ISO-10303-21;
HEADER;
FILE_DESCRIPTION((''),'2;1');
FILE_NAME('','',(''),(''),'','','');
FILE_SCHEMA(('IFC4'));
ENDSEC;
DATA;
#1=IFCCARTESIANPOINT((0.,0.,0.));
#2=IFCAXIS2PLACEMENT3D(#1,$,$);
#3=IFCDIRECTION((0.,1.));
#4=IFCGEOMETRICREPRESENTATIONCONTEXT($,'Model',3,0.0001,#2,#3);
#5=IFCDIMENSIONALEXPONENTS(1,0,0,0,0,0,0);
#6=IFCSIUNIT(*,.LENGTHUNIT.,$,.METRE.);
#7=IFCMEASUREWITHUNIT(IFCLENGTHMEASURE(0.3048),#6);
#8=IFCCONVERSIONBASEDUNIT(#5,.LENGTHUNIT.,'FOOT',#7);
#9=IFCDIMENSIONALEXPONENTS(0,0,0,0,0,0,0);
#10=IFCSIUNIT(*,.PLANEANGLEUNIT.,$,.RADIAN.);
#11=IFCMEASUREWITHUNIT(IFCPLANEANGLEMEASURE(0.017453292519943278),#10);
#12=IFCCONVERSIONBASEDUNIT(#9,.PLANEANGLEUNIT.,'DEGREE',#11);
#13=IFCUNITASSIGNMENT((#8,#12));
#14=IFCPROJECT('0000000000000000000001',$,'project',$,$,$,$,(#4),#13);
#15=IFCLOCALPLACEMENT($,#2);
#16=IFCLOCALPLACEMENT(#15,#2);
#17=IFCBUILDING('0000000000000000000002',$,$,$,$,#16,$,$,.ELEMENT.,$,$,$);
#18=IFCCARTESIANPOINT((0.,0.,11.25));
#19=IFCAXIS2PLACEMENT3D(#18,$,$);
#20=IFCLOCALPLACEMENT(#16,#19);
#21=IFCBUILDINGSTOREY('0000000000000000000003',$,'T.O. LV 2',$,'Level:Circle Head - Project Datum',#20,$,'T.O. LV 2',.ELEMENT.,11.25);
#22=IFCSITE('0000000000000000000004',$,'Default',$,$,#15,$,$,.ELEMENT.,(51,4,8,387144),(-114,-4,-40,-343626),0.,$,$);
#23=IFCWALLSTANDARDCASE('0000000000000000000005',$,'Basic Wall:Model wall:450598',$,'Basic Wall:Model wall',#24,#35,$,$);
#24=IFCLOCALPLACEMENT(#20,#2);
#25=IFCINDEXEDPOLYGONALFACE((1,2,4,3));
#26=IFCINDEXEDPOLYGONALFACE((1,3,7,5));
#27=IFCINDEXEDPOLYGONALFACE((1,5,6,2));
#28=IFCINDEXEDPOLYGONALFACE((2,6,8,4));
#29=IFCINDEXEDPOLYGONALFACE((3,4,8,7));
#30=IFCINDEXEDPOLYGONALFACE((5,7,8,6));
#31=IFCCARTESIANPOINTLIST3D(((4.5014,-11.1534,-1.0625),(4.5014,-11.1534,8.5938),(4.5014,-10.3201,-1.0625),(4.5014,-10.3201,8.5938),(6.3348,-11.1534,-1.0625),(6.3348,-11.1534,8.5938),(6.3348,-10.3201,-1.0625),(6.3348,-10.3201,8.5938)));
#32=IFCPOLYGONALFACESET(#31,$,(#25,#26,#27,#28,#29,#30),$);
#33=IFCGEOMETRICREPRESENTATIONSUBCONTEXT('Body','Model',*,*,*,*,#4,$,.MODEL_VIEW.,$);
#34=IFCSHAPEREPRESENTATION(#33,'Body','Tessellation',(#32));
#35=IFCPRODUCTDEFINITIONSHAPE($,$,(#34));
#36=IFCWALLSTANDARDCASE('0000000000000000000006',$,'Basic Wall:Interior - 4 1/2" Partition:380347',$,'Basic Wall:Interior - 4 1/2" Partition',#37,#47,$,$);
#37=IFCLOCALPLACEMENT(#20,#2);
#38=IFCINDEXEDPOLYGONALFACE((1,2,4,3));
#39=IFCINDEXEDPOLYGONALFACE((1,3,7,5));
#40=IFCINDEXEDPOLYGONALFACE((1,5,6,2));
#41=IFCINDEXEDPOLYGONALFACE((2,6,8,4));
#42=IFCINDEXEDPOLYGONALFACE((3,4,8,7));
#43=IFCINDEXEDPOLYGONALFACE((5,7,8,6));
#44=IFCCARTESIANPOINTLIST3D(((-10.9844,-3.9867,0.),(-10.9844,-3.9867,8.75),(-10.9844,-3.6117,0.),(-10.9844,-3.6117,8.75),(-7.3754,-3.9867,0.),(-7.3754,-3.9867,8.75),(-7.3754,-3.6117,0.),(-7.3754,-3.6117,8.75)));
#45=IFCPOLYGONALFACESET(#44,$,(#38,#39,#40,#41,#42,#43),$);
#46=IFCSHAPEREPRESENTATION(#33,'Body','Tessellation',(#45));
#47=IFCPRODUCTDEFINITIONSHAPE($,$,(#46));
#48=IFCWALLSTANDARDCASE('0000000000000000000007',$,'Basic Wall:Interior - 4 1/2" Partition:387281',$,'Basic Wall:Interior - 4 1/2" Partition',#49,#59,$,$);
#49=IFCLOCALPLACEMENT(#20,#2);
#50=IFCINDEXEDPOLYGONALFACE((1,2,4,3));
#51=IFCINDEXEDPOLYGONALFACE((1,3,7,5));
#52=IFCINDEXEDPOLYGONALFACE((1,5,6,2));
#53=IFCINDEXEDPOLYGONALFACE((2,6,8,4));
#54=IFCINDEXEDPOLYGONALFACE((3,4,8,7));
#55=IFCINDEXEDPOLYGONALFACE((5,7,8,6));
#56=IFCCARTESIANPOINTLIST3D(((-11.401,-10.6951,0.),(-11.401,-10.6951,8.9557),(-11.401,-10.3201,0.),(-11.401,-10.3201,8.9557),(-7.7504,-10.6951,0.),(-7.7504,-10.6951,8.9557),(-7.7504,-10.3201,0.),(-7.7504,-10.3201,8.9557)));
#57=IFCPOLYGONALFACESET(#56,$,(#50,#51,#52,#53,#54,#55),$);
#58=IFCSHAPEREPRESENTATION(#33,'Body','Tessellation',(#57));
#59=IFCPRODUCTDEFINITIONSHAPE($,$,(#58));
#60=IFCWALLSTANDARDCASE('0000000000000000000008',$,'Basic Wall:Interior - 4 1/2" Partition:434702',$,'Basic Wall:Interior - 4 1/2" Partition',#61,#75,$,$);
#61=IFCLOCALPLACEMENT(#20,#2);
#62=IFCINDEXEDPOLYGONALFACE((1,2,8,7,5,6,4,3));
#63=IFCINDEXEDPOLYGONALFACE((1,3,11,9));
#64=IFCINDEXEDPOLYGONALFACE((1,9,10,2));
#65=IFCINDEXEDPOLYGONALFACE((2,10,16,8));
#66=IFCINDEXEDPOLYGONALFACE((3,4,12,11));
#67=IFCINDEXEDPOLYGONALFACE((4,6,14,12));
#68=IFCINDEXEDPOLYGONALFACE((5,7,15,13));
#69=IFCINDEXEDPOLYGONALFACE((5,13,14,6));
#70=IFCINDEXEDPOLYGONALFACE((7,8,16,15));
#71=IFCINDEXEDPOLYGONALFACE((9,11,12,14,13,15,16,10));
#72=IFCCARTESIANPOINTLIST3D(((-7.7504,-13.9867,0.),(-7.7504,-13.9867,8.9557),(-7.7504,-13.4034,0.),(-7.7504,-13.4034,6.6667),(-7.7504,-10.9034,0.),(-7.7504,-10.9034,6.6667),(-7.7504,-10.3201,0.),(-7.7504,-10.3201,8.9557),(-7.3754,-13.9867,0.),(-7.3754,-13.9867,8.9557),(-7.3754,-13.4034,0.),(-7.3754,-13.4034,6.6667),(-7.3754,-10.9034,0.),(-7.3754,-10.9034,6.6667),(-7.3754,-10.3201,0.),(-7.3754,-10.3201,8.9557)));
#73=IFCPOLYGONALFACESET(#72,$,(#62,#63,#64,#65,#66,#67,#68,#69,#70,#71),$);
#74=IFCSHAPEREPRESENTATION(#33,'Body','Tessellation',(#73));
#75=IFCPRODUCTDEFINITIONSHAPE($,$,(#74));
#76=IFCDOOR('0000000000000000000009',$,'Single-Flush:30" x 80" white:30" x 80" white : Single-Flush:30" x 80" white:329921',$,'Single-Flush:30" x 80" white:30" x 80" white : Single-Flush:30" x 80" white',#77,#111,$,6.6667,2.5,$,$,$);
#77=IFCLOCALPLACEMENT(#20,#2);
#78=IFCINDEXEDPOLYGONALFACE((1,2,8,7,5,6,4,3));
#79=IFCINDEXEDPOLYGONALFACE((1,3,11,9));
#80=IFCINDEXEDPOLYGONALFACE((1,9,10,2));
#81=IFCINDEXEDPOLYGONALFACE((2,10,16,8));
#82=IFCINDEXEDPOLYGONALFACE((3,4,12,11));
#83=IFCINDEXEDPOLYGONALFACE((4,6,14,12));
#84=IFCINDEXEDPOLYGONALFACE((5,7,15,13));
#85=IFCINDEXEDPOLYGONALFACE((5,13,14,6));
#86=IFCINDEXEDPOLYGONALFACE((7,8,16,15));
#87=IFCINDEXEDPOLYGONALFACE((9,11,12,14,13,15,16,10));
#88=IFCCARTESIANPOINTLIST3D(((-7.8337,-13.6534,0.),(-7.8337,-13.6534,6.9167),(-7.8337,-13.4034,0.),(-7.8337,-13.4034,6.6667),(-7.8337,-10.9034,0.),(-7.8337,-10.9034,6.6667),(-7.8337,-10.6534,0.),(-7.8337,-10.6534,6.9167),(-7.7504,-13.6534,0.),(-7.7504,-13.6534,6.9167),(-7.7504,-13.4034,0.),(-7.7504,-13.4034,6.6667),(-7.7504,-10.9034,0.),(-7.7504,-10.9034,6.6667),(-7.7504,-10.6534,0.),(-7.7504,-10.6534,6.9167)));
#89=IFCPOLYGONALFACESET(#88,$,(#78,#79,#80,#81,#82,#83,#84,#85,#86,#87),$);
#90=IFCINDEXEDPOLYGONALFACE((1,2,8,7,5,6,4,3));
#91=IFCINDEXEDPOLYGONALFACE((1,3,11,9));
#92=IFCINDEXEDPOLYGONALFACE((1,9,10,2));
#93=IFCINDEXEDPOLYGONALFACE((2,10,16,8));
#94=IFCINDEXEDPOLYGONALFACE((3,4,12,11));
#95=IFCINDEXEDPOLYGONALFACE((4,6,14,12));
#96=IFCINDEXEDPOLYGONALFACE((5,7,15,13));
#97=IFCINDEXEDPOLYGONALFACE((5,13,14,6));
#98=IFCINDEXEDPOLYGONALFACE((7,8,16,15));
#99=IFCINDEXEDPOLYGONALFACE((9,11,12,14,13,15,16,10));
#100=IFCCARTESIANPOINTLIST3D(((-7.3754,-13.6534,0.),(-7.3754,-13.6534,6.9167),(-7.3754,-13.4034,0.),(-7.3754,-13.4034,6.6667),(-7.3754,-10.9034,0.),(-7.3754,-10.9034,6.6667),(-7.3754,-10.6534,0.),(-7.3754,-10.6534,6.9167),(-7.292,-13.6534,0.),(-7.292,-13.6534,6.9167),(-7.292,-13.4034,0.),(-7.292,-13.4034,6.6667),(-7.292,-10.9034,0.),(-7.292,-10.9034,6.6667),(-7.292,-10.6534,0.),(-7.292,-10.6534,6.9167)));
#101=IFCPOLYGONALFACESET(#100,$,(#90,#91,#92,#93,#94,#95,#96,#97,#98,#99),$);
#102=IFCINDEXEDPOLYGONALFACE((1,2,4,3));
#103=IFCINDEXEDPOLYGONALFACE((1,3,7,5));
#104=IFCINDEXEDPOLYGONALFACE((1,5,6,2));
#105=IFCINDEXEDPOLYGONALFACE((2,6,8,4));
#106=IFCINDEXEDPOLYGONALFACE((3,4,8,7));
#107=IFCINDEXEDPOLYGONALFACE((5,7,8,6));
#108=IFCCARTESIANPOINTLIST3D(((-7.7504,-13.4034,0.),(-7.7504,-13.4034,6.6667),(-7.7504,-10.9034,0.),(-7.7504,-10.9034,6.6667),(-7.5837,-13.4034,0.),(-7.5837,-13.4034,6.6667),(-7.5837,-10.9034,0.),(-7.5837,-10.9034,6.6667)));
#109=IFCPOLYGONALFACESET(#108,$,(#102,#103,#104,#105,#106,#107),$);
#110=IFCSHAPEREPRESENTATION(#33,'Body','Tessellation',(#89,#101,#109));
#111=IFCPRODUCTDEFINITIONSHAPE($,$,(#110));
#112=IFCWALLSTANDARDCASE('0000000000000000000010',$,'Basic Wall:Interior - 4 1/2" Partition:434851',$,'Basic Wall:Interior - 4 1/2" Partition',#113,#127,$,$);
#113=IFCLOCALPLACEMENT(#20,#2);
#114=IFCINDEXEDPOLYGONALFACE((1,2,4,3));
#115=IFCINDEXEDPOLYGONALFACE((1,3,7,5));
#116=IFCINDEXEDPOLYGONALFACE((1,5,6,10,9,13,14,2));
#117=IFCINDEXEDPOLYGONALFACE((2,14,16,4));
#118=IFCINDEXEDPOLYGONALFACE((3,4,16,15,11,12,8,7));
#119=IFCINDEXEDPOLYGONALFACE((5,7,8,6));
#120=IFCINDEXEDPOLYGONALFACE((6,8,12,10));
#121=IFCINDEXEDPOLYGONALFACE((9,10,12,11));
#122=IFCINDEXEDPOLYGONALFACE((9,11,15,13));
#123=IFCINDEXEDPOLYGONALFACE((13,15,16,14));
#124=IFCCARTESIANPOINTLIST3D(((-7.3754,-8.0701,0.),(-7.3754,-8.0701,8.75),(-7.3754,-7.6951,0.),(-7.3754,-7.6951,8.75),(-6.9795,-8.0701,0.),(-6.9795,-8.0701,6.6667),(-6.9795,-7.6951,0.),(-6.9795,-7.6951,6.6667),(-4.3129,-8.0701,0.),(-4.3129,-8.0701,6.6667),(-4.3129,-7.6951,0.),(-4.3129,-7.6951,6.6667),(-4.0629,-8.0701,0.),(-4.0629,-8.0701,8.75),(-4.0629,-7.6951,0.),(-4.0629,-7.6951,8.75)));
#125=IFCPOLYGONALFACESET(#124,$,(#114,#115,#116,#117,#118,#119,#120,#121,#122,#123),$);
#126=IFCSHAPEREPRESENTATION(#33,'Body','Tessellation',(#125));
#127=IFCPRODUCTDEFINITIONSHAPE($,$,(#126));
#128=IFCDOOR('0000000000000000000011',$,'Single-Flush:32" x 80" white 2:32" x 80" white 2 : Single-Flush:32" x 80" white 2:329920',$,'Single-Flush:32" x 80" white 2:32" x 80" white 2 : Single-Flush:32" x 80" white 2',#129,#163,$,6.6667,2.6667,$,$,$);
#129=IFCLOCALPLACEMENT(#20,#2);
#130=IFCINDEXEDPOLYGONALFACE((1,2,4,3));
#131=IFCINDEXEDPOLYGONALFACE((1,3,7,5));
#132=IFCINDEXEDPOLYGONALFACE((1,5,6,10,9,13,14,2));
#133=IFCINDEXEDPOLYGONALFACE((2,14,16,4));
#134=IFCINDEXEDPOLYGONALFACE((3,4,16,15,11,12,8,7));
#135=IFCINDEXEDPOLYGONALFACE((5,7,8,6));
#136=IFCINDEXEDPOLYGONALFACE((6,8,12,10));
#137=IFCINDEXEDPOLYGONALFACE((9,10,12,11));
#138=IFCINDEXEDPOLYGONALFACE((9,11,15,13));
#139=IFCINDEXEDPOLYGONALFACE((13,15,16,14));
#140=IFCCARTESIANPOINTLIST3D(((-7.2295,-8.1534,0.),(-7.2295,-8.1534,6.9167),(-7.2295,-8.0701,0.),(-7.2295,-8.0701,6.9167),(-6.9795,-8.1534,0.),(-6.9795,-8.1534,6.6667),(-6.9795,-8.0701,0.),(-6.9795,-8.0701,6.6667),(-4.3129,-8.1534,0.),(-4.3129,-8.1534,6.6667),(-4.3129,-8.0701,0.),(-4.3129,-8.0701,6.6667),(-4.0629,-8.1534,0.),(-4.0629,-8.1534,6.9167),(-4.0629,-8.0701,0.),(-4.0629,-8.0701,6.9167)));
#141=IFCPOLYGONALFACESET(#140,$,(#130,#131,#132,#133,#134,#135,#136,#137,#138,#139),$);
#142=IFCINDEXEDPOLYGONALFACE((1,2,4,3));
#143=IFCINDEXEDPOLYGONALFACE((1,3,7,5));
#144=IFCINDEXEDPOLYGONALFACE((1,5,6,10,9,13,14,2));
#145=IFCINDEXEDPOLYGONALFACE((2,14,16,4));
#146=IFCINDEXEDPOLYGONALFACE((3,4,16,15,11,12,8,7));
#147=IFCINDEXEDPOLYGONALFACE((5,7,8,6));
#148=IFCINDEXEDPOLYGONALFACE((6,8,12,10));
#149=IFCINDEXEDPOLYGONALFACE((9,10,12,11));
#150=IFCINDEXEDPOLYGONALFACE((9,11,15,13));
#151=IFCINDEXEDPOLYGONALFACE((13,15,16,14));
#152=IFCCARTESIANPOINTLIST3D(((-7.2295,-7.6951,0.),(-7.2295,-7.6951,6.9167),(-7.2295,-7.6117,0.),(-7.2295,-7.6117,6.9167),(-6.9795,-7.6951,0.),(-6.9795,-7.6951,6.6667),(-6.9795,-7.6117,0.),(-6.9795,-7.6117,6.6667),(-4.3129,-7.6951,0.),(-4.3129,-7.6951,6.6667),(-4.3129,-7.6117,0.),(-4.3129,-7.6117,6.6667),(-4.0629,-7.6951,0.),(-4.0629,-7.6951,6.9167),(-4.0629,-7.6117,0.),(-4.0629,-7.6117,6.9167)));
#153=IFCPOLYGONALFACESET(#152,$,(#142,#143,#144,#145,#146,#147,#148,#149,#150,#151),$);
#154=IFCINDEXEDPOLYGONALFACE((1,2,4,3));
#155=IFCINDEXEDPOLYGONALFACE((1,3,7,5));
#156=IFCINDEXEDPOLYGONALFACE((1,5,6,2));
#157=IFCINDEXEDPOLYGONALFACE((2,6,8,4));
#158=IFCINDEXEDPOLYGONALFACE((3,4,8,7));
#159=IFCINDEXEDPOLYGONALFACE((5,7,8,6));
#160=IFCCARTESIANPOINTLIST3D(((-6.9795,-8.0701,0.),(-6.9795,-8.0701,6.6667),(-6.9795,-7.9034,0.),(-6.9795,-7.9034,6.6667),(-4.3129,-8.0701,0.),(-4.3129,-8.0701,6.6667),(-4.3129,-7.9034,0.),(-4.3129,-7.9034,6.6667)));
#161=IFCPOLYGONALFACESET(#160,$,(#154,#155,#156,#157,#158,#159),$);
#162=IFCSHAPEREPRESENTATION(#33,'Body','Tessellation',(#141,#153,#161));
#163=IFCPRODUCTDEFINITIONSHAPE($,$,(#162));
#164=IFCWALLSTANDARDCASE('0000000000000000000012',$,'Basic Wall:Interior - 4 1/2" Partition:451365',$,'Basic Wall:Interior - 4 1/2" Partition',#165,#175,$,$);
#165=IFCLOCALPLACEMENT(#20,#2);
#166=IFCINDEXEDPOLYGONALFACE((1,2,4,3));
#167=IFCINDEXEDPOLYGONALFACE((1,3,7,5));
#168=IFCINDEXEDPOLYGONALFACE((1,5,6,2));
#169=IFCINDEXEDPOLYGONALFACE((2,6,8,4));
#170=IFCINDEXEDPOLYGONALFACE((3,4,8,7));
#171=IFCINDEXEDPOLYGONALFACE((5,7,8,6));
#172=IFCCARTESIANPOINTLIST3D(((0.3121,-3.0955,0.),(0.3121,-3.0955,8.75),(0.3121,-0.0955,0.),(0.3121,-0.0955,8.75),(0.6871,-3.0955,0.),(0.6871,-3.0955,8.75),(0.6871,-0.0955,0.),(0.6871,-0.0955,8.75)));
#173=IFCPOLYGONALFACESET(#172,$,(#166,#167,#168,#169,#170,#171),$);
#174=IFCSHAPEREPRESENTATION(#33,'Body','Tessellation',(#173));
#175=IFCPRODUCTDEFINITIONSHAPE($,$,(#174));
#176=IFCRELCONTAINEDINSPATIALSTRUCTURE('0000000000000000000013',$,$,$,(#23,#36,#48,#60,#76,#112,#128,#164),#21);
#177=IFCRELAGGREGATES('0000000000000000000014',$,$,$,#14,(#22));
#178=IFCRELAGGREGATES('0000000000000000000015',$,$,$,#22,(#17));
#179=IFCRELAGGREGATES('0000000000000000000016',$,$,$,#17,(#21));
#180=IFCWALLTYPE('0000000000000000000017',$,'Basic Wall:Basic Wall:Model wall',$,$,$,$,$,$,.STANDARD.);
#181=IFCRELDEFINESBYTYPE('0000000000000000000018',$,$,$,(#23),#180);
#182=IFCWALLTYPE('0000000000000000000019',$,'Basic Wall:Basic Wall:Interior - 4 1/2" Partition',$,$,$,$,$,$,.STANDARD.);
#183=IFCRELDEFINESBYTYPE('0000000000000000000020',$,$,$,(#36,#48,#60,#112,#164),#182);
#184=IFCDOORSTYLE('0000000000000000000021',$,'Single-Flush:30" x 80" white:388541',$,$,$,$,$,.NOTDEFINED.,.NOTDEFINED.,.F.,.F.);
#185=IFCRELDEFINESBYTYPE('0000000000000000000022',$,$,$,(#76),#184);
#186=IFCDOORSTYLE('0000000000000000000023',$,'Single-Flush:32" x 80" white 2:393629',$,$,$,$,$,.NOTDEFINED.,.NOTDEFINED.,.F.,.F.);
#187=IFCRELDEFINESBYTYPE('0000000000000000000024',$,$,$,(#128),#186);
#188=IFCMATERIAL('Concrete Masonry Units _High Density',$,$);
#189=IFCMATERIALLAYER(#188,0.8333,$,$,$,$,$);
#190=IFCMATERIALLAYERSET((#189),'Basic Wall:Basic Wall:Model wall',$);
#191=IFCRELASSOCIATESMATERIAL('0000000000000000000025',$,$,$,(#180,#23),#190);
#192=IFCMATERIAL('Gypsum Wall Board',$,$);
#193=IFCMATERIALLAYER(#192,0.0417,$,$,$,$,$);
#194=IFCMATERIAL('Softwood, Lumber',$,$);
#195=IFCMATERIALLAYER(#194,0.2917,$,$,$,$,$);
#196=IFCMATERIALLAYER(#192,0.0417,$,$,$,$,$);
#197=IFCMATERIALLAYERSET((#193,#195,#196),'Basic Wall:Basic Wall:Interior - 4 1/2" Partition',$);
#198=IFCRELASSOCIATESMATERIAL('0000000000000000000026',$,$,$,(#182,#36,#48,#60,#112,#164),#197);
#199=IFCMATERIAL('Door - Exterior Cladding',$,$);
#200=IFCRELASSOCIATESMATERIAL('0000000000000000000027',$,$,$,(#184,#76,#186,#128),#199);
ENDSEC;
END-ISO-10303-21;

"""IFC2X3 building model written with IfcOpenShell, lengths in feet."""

from ifc_helpers import new_model, entity, si_unit, converted_unit, direction, frame, frame_2d, origin, origin_2d_with_axis, place, context, subcontext, project, spatial, polyline, rectangle, outline, extrude, source, transform, mapped, material, layer, layer_set, layer_usage, type_object, type_shapes, element, fill, save


model = new_model("IFC2X3")

# Units and contexts
model_context = context("Model", 3, precision=0.0001, world=origin(), true_north=direction((0.0, 1.0)))
body_context = subcontext(model_context, "Body", "Model", "MODEL_VIEW")
ifc_project = project(units=[converted_unit("LENGTHUNIT", "FOOT", entity("IfcLengthMeasure", 0.3048), si_unit("LENGTHUNIT", "METRE"), dimensions=[1, 0, 0, 0, 0, 0, 0]), converted_unit("PLANEANGLEUNIT", "DEGREE", entity("IfcPlaneAngleMeasure", 0.017453292519943278), si_unit("PLANEANGLEUNIT", "RADIAN"), dimensions=[0, 0, 0, 0, 0, 0, 0])], contexts=[model_context])

# Site, building, storey
site_placement = place(None, origin())
site = spatial("IfcSite", under=ifc_project, at=site_placement, Name="Default", CompositionType="ELEMENT", RefLatitude=(51, 4, 8, 387144), RefLongitude=(-114, -4, -40, -343626), RefElevation=0.0)
building_placement = place(site_placement, origin())
building = spatial("IfcBuilding", under=site, at=building_placement, CompositionType="ELEMENT")
storey_placement = place(building_placement, frame((0.0, 0.0, 11.25)))
storey = spatial("IfcBuildingStorey", under=building, at=storey_placement, Name="T.O. LV 2", ObjectType="Level:Circle Head - Project Datum", LongName="T.O. LV 2", CompositionType="ELEMENT", Elevation=11.25)

# Shared definitions
ifc_material_1 = material(Name="Gypsum Wall Board")

# Shared definitions
ifc_material_2 = material(Name="Concrete Masonry Units _High Density")
ifc_layer_1 = layer(ifc_material_2, 0.8333)
ifc_layer_set_1 = layer_set([ifc_layer_1], Name="Basic Wall:Basic Wall:Model wall")
wall_type_1 = type_object("IfcWallType", Name="Basic Wall:Basic Wall:Model wall", PredefinedType="STANDARD", material=ifc_layer_set_1)

# Walls
ifc_layer_usage_1 = layer_usage(ifc_layer_set_1, "AXIS2", "NEGATIVE", 0.4167)
wall_1_placement = place(storey_placement, frame((6.3348, -10.7367, -1.0625), z_axis=(0.0, 0.0, 1.0), x_axis=(-1.0, 0.0, 0.0)))
element("IfcWallStandardCase", 1, at=wall_1_placement, inside=storey, type_object=wall_type_1, material=ifc_layer_usage_1, Name="Basic Wall:Model wall:450598", ObjectType="Basic Wall:Model wall", context=body_context, shape_type="SweptSolid", body=[
    extrude(rectangle(XDim=1.8333, YDim=0.8333, at=frame_2d((0.9167, 0.0), x_axis=(-1.0, 0.0))), origin(), (0.0, 0.0, 1.0), 9.6563),
])
ifc_layer_2 = layer(ifc_material_1, 0.0417)
ifc_material_3 = material(Name="Softwood, Lumber")
ifc_layer_3 = layer(ifc_material_3, 0.2917)
ifc_layer_4 = layer(ifc_material_1, 0.0417)
ifc_layer_set_2 = layer_set([ifc_layer_2, ifc_layer_3, ifc_layer_4], Name="Basic Wall:Basic Wall:Interior - 4 1/2\" Partition")
ifc_layer_usage_2 = layer_usage(ifc_layer_set_2, "AXIS2", "NEGATIVE", 0.1875)
wall_type_2 = type_object("IfcWallType", Name="Basic Wall:Basic Wall:Interior - 4 1/2\" Partition", PredefinedType="STANDARD", material=ifc_layer_set_2)
wall_2_placement = place(storey_placement, frame((-10.9844, -3.7992, 0.0)))
element("IfcWallStandardCase", 2, at=wall_2_placement, inside=storey, type_object=wall_type_2, material=ifc_layer_usage_2, Name="Basic Wall:Interior - 4 1/2\" Partition:380347", ObjectType="Basic Wall:Interior - 4 1/2\" Partition", context=body_context, shape_type="SweptSolid", body=[
    extrude(rectangle(XDim=3.609, YDim=0.375, at=frame_2d((1.8045, 0.0), x_axis=(-1.0, 0.0))), origin(), (0.0, 0.0, 1.0), 8.75),
])
ifc_layer_usage_3 = layer_usage(ifc_layer_set_2, "AXIS2", "NEGATIVE", 0.1875)
wall_3_placement = place(storey_placement, frame((-7.7504, -10.5076, 0.0), z_axis=(0.0, 0.0, 1.0), x_axis=(-1.0, 0.0, 0.0)))
element("IfcWallStandardCase", 3, at=wall_3_placement, inside=storey, type_object=wall_type_2, material=ifc_layer_usage_3, Name="Basic Wall:Interior - 4 1/2\" Partition:387281", ObjectType="Basic Wall:Interior - 4 1/2\" Partition", context=body_context, shape_type="SweptSolid", body=[
    extrude(rectangle(XDim=3.6507, YDim=0.375, at=frame_2d((1.8253, 0.0), x_axis=(-1.0, 0.0))), origin(), (0.0, 0.0, 1.0), 8.9557),
])

# Walls, openings, doors
ifc_layer_usage_4 = layer_usage(ifc_layer_set_2, "AXIS2", "NEGATIVE", 0.1875)
wall_4_placement = place(storey_placement, frame((-7.5629, -10.3201, 0.0), z_axis=(0.0, 0.0, 1.0), x_axis=(0.0, -1.0, 0.0)))
wall_4 = element("IfcWallStandardCase", 4, at=wall_4_placement, inside=storey, type_object=wall_type_2, material=ifc_layer_usage_4, Name="Basic Wall:Interior - 4 1/2\" Partition:434702", ObjectType="Basic Wall:Interior - 4 1/2\" Partition", context=body_context, shape_type="SweptSolid", body=[
    extrude(rectangle(XDim=3.6667, YDim=0.375, at=frame_2d((1.8333, 0.0), x_axis=(1.0, 0.0))), origin(), (0.0, 0.0, 1.0), 8.9557),
])
opening_1_placement = place(wall_4_placement, frame((-10.3201, 7.5629, 0.0), z_axis=(0.0, 0.0, 1.0), x_axis=(0.0, 1.0, 0.0)))
opening_1 = element("IfcOpeningElement", 5, at=opening_1_placement, cuts=wall_4, ObjectType="Opening", context=body_context, shape_type="SweptSolid", body=[
    extrude(rectangle(XDim=6.6667, YDim=2.5, at=frame_2d((0.0, 0.0), x_axis=(0.0, 1.0))), frame((-7.7541, -12.1534, 3.3333), z_axis=(1.0, 0.0, 0.0), x_axis=(0.0, -1.0, 0.0)), (0.0, 0.0, 1.0), 0.3825),
])
ifc_material_4 = material(Name="Door - Exterior Cladding")
door_style_1 = type_object("IfcDoorStyle", Name="Single-Flush:30\" x 80\" white:388541", ConstructionType="NOTDEFINED", OperationType="NOTDEFINED", ParameterTakesPrecedence=False, Sizeable=False, material=ifc_material_4)
shared_shape_1 = source(origin(), body_context, "Body", "SweptSolid", [
    extrude(outline(polyline([(-3.5208, -1.5), (3.3958, -1.5), (3.3958, -1.25), (-3.2708, -1.25), (-3.2708, 1.25), (3.3958, 1.25), (3.3958, 1.5), (-3.5208, 1.5), (-3.5208, -1.5)])), frame((1.25, 0.3788, 3.3958), z_axis=(0.0, 1.0, 0.0), x_axis=(0.0, 0.0, -1.0)), (0.0, 0.0, 1.0), 0.0833),
    extrude(outline(polyline([(-1.5, -3.3958), (-1.25, -3.3958), (-1.25, 3.2708), (1.25, 3.2708), (1.25, -3.3958), (1.5, -3.3958), (1.5, 3.5208), (-1.5, 3.5208), (-1.5, -3.3958)])), frame((1.25, -0.0796, 3.3958), z_axis=(0.0, 1.0, 0.0), x_axis=(-1.0, 0.0, 0.0)), (0.0, 0.0, 1.0), 0.0833),
    extrude(rectangle(XDim=2.5, YDim=0.1667, at=origin_2d_with_axis()), frame((1.25, 0.2954, 0.0), z_axis=(0.0, 0.0, 1.0), x_axis=(-1.0, 0.0, 0.0)), (0.0, 0.0, 1.0), 6.6667),
])
type_shapes(door_style_1, [shared_shape_1])
door_1_placement = place(opening_1_placement, frame((-7.3716, -13.4034, 0.0), z_axis=(0.0, 0.0, 1.0), x_axis=(0.0, 1.0, 0.0)))
door_1 = element("IfcDoor", 6, at=door_1_placement, inside=storey, type_object=door_style_1, material=ifc_material_4, Name="Single-Flush:30\" x 80\" white:30\" x 80\" white : Single-Flush:30\" x 80\" white:329921", ObjectType="Single-Flush:30\" x 80\" white:30\" x 80\" white : Single-Flush:30\" x 80\" white", OverallHeight=6.6667, OverallWidth=2.5, context=body_context, shape_type="MappedRepresentation", body=[
    mapped(shared_shape_1, transform((0.0, 0.0, 0.0), scale=1.0)),
])
fill(opening_1, door_1)
ifc_layer_usage_5 = layer_usage(ifc_layer_set_2, "AXIS2", "NEGATIVE", 0.1875)
wall_5_placement = place(storey_placement, frame((-7.3754, -7.8826, 0.0)))
wall_5 = element("IfcWallStandardCase", 7, at=wall_5_placement, inside=storey, type_object=wall_type_2, material=ifc_layer_usage_5, Name="Basic Wall:Interior - 4 1/2\" Partition:434851", ObjectType="Basic Wall:Interior - 4 1/2\" Partition", context=body_context, shape_type="SweptSolid", body=[
    extrude(rectangle(XDim=3.3125, YDim=0.375, at=frame_2d((1.6563, 0.0), x_axis=(1.0, 0.0))), origin(), (0.0, 0.0, 1.0), 8.75),
])
opening_2_placement = place(wall_5_placement, frame((7.3754, 7.8826, 0.0)))
opening_2 = element("IfcOpeningElement", 8, at=opening_2_placement, cuts=wall_5, ObjectType="Opening", context=body_context, shape_type="SweptSolid", body=[
    extrude(rectangle(XDim=6.6667, YDim=2.6667, at=frame_2d((0.0, 0.0), x_axis=(0.0, 1.0))), frame((-5.6462, -8.0738, 3.3333), z_axis=(0.0, 1.0, 0.0), x_axis=(1.0, 0.0, 0.0)), (0.0, 0.0, 1.0), 0.3825),
])
door_style_2 = type_object("IfcDoorStyle", Name="Single-Flush:32\" x 80\" white 2:393629", ConstructionType="NOTDEFINED", OperationType="NOTDEFINED", ParameterTakesPrecedence=False, Sizeable=False, material=ifc_material_4)
shared_shape_2 = source(origin(), body_context, "Body", "SweptSolid", [
    extrude(outline(polyline([(-3.5208, -1.5833), (3.3958, -1.5833), (3.3958, -1.3333), (-3.2708, -1.3333), (-3.2708, 1.3333), (3.3958, 1.3333), (3.3958, 1.5833), (-3.5208, 1.5833), (-3.5208, -1.5833)])), frame((1.3333, 0.3788, 3.3958), z_axis=(0.0, 1.0, 0.0), x_axis=(0.0, 0.0, -1.0)), (0.0, 0.0, 1.0), 0.0833),
    extrude(outline(polyline([(-1.5833, -3.3958), (-1.3333, -3.3958), (-1.3333, 3.2708), (1.3333, 3.2708), (1.3333, -3.3958), (1.5833, -3.3958), (1.5833, 3.5208), (-1.5833, 3.5208), (-1.5833, -3.3958)])), frame((1.3333, -0.0796, 3.3958), z_axis=(0.0, 1.0, 0.0), x_axis=(-1.0, 0.0, 0.0)), (0.0, 0.0, 1.0), 0.0833),
    extrude(rectangle(XDim=2.6667, YDim=0.1667, at=frame_2d((0.0, 0.0), x_axis=(1.0, 0.0))), frame((1.3333, 0.2954, 0.0), z_axis=(0.0, 0.0, 1.0), x_axis=(-1.0, 0.0, 0.0)), (0.0, 0.0, 1.0), 6.6667),
])
type_shapes(door_style_2, [shared_shape_2])
door_2_placement = place(opening_2_placement, frame((-4.3129, -7.6913, 0.0), z_axis=(0.0, 0.0, 1.0), x_axis=(-1.0, 0.0, 0.0)))
door_2 = element("IfcDoor", 9, at=door_2_placement, inside=storey, type_object=door_style_2, material=ifc_material_4, Name="Single-Flush:32\" x 80\" white 2:32\" x 80\" white 2 : Single-Flush:32\" x 80\" white 2:329920", ObjectType="Single-Flush:32\" x 80\" white 2:32\" x 80\" white 2 : Single-Flush:32\" x 80\" white 2", OverallHeight=6.6667, OverallWidth=2.6667, context=body_context, shape_type="MappedRepresentation", body=[
    mapped(shared_shape_2, transform((0.0, 0.0, 0.0), scale=1.0)),
])
fill(opening_2, door_2)

# Wall
ifc_layer_usage_6 = layer_usage(ifc_layer_set_2, "AXIS2", "NEGATIVE", 0.1875)
wall_6_placement = place(storey_placement, frame((0.4996, -0.0955, 0.0), z_axis=(0.0, 0.0, 1.0), x_axis=(0.0, -1.0, 0.0)))
element("IfcWallStandardCase", 10, at=wall_6_placement, inside=storey, type_object=wall_type_2, material=ifc_layer_usage_6, Name="Basic Wall:Interior - 4 1/2\" Partition:451365", ObjectType="Basic Wall:Interior - 4 1/2\" Partition", context=body_context, shape_type="SweptSolid", body=[
    extrude(rectangle(XDim=3.0, YDim=0.375, at=frame_2d((1.5, 0.0), x_axis=(-1.0, 0.0))), origin(), (0.0, 0.0, 1.0), 8.75),
])

save(model, "model.ifc")
